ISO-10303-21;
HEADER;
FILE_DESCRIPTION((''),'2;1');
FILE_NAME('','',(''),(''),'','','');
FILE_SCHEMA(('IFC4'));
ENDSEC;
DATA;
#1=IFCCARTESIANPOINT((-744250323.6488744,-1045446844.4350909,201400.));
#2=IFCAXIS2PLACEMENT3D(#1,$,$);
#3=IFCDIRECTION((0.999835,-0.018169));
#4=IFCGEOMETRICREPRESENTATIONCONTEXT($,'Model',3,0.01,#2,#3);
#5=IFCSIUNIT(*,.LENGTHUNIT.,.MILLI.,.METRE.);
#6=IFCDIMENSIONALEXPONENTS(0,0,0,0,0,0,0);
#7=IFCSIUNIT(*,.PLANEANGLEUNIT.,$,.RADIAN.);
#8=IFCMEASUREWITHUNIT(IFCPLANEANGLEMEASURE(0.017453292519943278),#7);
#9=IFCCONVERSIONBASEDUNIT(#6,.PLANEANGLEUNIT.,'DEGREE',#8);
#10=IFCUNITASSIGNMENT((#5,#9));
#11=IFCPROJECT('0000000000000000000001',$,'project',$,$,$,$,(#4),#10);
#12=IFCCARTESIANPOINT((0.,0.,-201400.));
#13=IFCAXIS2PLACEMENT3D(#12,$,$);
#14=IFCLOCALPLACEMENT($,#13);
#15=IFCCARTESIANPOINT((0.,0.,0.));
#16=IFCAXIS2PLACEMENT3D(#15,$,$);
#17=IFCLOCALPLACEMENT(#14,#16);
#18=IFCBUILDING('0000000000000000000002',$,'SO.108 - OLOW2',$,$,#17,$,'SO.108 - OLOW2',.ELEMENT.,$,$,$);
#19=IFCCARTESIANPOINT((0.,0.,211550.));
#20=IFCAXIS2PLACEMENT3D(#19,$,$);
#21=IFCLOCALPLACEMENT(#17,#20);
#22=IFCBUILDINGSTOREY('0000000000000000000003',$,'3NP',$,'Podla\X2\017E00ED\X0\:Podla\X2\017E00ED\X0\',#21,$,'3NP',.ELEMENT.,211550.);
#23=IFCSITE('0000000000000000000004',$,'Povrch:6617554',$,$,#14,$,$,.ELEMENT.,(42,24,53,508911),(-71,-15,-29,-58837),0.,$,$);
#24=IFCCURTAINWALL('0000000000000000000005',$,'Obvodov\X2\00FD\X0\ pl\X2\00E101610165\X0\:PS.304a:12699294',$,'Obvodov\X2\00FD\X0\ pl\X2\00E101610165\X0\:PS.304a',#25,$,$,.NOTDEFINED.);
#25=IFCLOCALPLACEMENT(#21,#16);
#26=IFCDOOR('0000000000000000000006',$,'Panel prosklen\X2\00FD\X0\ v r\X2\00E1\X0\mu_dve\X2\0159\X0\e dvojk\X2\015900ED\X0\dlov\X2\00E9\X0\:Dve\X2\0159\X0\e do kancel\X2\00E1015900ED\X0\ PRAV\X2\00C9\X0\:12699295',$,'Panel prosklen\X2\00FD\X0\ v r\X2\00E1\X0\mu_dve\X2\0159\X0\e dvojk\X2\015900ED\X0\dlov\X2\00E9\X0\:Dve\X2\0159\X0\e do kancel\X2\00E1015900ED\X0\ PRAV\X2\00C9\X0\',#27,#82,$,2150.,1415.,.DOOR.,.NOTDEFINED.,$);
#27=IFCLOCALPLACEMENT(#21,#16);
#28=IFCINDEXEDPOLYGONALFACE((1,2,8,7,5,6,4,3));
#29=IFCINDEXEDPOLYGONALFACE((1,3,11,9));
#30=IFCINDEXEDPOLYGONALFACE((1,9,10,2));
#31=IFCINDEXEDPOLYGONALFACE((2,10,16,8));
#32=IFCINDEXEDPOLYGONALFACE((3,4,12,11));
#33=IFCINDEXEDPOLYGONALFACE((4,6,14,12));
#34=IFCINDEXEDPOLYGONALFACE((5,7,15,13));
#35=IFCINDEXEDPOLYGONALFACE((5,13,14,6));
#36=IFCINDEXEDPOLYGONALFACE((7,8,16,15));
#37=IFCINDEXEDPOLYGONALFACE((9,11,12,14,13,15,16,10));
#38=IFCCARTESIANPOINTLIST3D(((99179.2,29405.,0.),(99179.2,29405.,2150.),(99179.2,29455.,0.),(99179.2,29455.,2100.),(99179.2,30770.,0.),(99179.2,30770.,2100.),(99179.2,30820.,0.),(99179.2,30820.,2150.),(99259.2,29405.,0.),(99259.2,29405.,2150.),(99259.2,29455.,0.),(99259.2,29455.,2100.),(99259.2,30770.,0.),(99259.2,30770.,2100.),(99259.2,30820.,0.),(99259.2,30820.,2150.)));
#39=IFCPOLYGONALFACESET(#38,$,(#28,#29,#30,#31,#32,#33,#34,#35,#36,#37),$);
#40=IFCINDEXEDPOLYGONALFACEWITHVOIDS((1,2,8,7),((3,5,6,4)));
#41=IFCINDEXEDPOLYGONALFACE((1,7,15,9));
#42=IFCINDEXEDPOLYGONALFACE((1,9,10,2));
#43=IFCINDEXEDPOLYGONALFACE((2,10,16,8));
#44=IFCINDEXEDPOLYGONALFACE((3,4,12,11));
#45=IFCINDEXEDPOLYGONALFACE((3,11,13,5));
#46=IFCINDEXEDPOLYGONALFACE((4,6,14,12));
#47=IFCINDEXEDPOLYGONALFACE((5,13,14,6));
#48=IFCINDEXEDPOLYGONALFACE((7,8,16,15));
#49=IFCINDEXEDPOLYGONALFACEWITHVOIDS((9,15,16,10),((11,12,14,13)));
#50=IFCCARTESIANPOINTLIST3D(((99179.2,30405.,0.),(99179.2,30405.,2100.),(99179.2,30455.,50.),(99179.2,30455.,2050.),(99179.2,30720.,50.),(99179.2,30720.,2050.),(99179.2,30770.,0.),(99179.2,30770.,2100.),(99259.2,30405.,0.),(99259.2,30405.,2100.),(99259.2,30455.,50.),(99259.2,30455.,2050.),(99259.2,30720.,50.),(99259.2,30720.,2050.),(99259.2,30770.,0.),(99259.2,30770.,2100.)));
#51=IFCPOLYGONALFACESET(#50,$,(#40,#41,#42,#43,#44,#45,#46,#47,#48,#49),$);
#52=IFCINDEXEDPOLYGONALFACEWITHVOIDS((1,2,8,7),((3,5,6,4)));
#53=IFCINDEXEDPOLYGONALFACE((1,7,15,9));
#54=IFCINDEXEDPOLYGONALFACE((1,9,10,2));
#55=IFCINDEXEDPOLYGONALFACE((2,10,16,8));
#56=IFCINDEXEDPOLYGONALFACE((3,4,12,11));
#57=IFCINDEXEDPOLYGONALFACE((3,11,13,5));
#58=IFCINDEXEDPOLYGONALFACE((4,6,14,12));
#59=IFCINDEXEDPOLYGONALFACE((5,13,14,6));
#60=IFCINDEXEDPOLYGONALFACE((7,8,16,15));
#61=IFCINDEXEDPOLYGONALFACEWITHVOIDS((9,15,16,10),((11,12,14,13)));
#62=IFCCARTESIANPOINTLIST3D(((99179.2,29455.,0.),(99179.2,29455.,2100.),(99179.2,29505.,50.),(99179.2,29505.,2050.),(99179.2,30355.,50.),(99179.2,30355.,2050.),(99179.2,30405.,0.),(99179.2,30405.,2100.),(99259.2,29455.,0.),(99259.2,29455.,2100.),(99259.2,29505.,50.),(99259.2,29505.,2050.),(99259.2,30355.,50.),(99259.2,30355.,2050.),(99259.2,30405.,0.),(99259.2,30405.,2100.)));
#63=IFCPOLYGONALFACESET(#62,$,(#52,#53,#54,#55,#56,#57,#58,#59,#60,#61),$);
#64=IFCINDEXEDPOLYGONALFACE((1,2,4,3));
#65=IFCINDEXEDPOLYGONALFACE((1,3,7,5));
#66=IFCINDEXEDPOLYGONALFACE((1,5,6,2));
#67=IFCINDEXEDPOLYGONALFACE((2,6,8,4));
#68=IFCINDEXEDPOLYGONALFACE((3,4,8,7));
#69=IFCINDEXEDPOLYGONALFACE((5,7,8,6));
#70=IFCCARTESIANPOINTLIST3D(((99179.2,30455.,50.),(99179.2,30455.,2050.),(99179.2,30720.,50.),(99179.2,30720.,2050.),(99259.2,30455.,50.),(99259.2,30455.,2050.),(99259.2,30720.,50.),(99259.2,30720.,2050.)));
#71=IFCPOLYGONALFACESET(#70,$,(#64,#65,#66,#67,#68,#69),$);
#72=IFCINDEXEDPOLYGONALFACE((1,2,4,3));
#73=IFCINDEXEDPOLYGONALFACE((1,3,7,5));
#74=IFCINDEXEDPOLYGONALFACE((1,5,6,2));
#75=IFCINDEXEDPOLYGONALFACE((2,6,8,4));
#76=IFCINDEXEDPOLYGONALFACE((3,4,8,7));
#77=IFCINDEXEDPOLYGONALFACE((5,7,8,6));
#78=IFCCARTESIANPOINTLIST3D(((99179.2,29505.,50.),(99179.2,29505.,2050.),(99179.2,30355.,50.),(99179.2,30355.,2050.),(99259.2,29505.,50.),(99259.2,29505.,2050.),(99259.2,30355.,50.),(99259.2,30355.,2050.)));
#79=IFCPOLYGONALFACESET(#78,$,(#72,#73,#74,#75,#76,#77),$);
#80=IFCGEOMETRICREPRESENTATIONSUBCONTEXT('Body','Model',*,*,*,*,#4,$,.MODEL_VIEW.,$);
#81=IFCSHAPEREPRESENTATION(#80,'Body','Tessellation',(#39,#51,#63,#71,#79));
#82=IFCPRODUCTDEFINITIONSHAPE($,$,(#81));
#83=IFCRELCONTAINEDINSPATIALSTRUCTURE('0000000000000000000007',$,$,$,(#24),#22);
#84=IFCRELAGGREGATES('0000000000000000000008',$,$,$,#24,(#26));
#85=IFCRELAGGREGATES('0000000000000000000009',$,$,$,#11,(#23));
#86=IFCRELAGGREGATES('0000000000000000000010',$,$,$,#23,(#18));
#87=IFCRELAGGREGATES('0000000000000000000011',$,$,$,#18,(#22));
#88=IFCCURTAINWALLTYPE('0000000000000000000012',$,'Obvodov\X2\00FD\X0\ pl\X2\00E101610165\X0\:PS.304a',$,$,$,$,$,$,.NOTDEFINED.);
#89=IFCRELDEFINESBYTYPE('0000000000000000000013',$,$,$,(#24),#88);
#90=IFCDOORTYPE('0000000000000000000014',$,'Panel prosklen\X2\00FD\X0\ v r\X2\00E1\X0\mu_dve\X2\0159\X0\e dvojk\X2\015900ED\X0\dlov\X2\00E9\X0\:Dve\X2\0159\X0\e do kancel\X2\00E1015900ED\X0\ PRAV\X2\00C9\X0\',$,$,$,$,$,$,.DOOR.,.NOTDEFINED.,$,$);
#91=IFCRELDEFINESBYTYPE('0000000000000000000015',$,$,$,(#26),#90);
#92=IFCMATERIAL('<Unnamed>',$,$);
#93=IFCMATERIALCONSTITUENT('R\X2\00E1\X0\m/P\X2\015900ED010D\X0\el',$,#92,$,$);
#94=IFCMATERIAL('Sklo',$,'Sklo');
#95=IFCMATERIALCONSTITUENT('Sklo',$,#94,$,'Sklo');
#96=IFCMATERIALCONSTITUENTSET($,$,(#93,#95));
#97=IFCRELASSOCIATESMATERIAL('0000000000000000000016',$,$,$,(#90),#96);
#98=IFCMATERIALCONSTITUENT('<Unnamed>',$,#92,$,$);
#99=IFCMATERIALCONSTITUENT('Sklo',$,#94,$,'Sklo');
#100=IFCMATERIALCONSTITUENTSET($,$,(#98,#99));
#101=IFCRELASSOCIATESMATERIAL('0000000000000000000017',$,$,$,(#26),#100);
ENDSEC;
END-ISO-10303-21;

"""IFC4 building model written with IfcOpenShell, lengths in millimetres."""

from ifc_helpers import new_model, entity, si_unit, converted_unit, direction, frame, origin, place, context, subcontext, project, spatial, indexed_curve, outline, extrude, source, transform, mapped, material, constituent, constituent_set, type_object, type_shapes, element, aggregate, save


model = new_model("IFC4")

# Units and contexts
model_context = context("Model", 3, precision=0.01, world=frame((-744250323.6488744, -1045446844.4350909, 201400.0)), true_north=direction((0.999835, -0.018169)))
body_context = subcontext(model_context, "Body", "Model", "MODEL_VIEW")
ifc_project = project(units=[si_unit("LENGTHUNIT", "METRE", prefix="MILLI"), converted_unit("PLANEANGLEUNIT", "DEGREE", entity("IfcPlaneAngleMeasure", 0.017453292519943278), si_unit("PLANEANGLEUNIT", "RADIAN"), dimensions=[0, 0, 0, 0, 0, 0, 0])], contexts=[model_context])

# Site, building, storey
site_placement = place(None, frame((0.0, 0.0, -201400.0)))
site = spatial("IfcSite", under=ifc_project, at=site_placement, Name="Povrch:6617554", CompositionType="ELEMENT", RefLatitude=(42, 24, 53, 508911), RefLongitude=(-71, -15, -29, -58837), RefElevation=0.0)
building_placement = place(site_placement, origin())
building = spatial("IfcBuilding", under=site, at=building_placement, Name="SO.108 - OLOW2", LongName="SO.108 - OLOW2", CompositionType="ELEMENT")
storey_placement = place(building_placement, frame((0.0, 0.0, 211550.0)))
storey = spatial("IfcBuildingStorey", under=building, at=storey_placement, Name="3NP", ObjectType="Podlaží:Podlaží", LongName="3NP", CompositionType="ELEMENT", Elevation=211550.0)

# Curtain wall
ifc_material_1 = material(Name="<Unnamed>")
curtain_wall_type_1 = type_object("IfcCurtainWallType", Name="Obvodový plášť:PS.304a", PredefinedType="NOTDEFINED")
curtain_wall_1_placement = place(storey_placement, frame((0.0, 0.0, -211550.0)))
curtain_wall_1 = element("IfcCurtainWall", 1, at=curtain_wall_1_placement, inside=storey, type_object=curtain_wall_type_1, Name="Obvodový plášť:PS.304a:12699294", ObjectType="Obvodový plášť:PS.304a", PredefinedType="NOTDEFINED")

# Shared definitions
ifc_material_2 = material(Name="Sklo", Category="Sklo")

# Door
ifc_constituent_1 = constituent(ifc_material_1, Name="<Unnamed>")
ifc_constituent_2 = constituent(ifc_material_2, Name="Sklo", Category="Sklo")
ifc_constituent_set_1 = constituent_set(constituents=[ifc_constituent_1, ifc_constituent_2])
ifc_constituent_3 = constituent(ifc_material_1, Name="Rám/Příčel")
ifc_constituent_4 = constituent(ifc_material_2, Name="Sklo", Category="Sklo")
ifc_constituent_set_2 = constituent_set(constituents=[ifc_constituent_3, ifc_constituent_4])
door_type = type_object("IfcDoorType", Name="Panel prosklený v rámu_dveře dvojkřídlové:Dveře do kanceláří PRAVÉ", OperationType="NOTDEFINED", PredefinedType="DOOR", material=ifc_constituent_set_2)
shared_shape_1 = source(origin(), body_context, "Body", "SweptSolid", [
    extrude(outline(indexed_curve([(-707.5, -1087.5), (707.5, -1087.5), (707.5, 1062.5), (657.5, 1062.5), (657.5, -1037.5), (-657.5, -1037.5), (-657.5, 1062.5), (-707.5, 1062.5), (-707.5, -1087.5)], self_intersect=False)), frame((0.0, -40.0, 1062.5), z_axis=(0.0, 1.0, 0.0), x_axis=(1.0, 0.0, 0.0)), (0.0, 0.0, 1.0), 80.0),
    extrude(outline(indexed_curve([(-1050.0, -182.5), (1050.0, -182.5), (1050.0, 182.5), (-1050.0, 182.5), (-1050.0, -182.5)], self_intersect=False), holes=[indexed_curve([(-1000.0, -132.5), (-1000.0, 132.5), (1000.0, 132.5), (1000.0, -132.5), (-1000.0, -132.5)], self_intersect=False)]), frame((475.0, -40.0, 1050.0), z_axis=(0.0, 1.0, 0.0), x_axis=(0.0, 0.0, -1.0)), (0.0, 0.0, 1.0), 80.0),
    extrude(outline(indexed_curve([(-1050.0, -475.0), (1050.0, -475.0), (1050.0, 475.0), (-1050.0, 475.0), (-1050.0, -475.0)], self_intersect=False), holes=[indexed_curve([(-1000.0, -425.0), (-1000.0, 425.0), (1000.0, 425.0), (1000.0, -425.0), (-1000.0, -425.0)], self_intersect=False)]), frame((-182.5, -40.0, 1050.0), z_axis=(0.0, 1.0, 0.0), x_axis=(0.0, 0.0, -1.0)), (0.0, 0.0, 1.0), 80.0),
    extrude(outline(indexed_curve([(-40.0, -132.5), (40.0, -132.5), (40.0, 132.5), (-40.0, 132.5), (-40.0, -132.5)], self_intersect=False)), frame((475.0, 0.0, 50.0), z_axis=(0.0, 0.0, 1.0), x_axis=(0.0, 1.0, 0.0)), (0.0, 0.0, 1.0), 2000.0),
    extrude(outline(indexed_curve([(-40.0, -425.0), (40.0, -425.0), (40.0, 425.0), (-40.0, 425.0), (-40.0, -425.0)], self_intersect=False)), frame((-182.5, 0.0, 50.0), z_axis=(0.0, 0.0, 1.0), x_axis=(0.0, 1.0, 0.0)), (0.0, 0.0, 1.0), 2000.0),
])
type_shapes(door_type, [shared_shape_1])
door_placement = place(curtain_wall_1_placement, frame((99219.2, 30112.5, 211550.0), z_axis=(0.0, 0.0, 1.0), x_axis=(0.0, 1.0, 0.0)))
door = element("IfcDoor", 2, at=door_placement, type_object=door_type, material=ifc_constituent_set_1, Name="Panel prosklený v rámu_dveře dvojkřídlové:Dveře do kanceláří PRAVÉ:12699295", ObjectType="Panel prosklený v rámu_dveře dvojkřídlové:Dveře do kanceláří PRAVÉ", OperationType="NOTDEFINED", OverallHeight=2150.0, OverallWidth=1415.0, PredefinedType="DOOR", context=body_context, shape_type="MappedRepresentation", body=[
    mapped(shared_shape_1, transform((0.0, 0.0, 0.0), scale=1.0)),
])
aggregate(curtain_wall_1, [door])

save(model, "model.ifc")
